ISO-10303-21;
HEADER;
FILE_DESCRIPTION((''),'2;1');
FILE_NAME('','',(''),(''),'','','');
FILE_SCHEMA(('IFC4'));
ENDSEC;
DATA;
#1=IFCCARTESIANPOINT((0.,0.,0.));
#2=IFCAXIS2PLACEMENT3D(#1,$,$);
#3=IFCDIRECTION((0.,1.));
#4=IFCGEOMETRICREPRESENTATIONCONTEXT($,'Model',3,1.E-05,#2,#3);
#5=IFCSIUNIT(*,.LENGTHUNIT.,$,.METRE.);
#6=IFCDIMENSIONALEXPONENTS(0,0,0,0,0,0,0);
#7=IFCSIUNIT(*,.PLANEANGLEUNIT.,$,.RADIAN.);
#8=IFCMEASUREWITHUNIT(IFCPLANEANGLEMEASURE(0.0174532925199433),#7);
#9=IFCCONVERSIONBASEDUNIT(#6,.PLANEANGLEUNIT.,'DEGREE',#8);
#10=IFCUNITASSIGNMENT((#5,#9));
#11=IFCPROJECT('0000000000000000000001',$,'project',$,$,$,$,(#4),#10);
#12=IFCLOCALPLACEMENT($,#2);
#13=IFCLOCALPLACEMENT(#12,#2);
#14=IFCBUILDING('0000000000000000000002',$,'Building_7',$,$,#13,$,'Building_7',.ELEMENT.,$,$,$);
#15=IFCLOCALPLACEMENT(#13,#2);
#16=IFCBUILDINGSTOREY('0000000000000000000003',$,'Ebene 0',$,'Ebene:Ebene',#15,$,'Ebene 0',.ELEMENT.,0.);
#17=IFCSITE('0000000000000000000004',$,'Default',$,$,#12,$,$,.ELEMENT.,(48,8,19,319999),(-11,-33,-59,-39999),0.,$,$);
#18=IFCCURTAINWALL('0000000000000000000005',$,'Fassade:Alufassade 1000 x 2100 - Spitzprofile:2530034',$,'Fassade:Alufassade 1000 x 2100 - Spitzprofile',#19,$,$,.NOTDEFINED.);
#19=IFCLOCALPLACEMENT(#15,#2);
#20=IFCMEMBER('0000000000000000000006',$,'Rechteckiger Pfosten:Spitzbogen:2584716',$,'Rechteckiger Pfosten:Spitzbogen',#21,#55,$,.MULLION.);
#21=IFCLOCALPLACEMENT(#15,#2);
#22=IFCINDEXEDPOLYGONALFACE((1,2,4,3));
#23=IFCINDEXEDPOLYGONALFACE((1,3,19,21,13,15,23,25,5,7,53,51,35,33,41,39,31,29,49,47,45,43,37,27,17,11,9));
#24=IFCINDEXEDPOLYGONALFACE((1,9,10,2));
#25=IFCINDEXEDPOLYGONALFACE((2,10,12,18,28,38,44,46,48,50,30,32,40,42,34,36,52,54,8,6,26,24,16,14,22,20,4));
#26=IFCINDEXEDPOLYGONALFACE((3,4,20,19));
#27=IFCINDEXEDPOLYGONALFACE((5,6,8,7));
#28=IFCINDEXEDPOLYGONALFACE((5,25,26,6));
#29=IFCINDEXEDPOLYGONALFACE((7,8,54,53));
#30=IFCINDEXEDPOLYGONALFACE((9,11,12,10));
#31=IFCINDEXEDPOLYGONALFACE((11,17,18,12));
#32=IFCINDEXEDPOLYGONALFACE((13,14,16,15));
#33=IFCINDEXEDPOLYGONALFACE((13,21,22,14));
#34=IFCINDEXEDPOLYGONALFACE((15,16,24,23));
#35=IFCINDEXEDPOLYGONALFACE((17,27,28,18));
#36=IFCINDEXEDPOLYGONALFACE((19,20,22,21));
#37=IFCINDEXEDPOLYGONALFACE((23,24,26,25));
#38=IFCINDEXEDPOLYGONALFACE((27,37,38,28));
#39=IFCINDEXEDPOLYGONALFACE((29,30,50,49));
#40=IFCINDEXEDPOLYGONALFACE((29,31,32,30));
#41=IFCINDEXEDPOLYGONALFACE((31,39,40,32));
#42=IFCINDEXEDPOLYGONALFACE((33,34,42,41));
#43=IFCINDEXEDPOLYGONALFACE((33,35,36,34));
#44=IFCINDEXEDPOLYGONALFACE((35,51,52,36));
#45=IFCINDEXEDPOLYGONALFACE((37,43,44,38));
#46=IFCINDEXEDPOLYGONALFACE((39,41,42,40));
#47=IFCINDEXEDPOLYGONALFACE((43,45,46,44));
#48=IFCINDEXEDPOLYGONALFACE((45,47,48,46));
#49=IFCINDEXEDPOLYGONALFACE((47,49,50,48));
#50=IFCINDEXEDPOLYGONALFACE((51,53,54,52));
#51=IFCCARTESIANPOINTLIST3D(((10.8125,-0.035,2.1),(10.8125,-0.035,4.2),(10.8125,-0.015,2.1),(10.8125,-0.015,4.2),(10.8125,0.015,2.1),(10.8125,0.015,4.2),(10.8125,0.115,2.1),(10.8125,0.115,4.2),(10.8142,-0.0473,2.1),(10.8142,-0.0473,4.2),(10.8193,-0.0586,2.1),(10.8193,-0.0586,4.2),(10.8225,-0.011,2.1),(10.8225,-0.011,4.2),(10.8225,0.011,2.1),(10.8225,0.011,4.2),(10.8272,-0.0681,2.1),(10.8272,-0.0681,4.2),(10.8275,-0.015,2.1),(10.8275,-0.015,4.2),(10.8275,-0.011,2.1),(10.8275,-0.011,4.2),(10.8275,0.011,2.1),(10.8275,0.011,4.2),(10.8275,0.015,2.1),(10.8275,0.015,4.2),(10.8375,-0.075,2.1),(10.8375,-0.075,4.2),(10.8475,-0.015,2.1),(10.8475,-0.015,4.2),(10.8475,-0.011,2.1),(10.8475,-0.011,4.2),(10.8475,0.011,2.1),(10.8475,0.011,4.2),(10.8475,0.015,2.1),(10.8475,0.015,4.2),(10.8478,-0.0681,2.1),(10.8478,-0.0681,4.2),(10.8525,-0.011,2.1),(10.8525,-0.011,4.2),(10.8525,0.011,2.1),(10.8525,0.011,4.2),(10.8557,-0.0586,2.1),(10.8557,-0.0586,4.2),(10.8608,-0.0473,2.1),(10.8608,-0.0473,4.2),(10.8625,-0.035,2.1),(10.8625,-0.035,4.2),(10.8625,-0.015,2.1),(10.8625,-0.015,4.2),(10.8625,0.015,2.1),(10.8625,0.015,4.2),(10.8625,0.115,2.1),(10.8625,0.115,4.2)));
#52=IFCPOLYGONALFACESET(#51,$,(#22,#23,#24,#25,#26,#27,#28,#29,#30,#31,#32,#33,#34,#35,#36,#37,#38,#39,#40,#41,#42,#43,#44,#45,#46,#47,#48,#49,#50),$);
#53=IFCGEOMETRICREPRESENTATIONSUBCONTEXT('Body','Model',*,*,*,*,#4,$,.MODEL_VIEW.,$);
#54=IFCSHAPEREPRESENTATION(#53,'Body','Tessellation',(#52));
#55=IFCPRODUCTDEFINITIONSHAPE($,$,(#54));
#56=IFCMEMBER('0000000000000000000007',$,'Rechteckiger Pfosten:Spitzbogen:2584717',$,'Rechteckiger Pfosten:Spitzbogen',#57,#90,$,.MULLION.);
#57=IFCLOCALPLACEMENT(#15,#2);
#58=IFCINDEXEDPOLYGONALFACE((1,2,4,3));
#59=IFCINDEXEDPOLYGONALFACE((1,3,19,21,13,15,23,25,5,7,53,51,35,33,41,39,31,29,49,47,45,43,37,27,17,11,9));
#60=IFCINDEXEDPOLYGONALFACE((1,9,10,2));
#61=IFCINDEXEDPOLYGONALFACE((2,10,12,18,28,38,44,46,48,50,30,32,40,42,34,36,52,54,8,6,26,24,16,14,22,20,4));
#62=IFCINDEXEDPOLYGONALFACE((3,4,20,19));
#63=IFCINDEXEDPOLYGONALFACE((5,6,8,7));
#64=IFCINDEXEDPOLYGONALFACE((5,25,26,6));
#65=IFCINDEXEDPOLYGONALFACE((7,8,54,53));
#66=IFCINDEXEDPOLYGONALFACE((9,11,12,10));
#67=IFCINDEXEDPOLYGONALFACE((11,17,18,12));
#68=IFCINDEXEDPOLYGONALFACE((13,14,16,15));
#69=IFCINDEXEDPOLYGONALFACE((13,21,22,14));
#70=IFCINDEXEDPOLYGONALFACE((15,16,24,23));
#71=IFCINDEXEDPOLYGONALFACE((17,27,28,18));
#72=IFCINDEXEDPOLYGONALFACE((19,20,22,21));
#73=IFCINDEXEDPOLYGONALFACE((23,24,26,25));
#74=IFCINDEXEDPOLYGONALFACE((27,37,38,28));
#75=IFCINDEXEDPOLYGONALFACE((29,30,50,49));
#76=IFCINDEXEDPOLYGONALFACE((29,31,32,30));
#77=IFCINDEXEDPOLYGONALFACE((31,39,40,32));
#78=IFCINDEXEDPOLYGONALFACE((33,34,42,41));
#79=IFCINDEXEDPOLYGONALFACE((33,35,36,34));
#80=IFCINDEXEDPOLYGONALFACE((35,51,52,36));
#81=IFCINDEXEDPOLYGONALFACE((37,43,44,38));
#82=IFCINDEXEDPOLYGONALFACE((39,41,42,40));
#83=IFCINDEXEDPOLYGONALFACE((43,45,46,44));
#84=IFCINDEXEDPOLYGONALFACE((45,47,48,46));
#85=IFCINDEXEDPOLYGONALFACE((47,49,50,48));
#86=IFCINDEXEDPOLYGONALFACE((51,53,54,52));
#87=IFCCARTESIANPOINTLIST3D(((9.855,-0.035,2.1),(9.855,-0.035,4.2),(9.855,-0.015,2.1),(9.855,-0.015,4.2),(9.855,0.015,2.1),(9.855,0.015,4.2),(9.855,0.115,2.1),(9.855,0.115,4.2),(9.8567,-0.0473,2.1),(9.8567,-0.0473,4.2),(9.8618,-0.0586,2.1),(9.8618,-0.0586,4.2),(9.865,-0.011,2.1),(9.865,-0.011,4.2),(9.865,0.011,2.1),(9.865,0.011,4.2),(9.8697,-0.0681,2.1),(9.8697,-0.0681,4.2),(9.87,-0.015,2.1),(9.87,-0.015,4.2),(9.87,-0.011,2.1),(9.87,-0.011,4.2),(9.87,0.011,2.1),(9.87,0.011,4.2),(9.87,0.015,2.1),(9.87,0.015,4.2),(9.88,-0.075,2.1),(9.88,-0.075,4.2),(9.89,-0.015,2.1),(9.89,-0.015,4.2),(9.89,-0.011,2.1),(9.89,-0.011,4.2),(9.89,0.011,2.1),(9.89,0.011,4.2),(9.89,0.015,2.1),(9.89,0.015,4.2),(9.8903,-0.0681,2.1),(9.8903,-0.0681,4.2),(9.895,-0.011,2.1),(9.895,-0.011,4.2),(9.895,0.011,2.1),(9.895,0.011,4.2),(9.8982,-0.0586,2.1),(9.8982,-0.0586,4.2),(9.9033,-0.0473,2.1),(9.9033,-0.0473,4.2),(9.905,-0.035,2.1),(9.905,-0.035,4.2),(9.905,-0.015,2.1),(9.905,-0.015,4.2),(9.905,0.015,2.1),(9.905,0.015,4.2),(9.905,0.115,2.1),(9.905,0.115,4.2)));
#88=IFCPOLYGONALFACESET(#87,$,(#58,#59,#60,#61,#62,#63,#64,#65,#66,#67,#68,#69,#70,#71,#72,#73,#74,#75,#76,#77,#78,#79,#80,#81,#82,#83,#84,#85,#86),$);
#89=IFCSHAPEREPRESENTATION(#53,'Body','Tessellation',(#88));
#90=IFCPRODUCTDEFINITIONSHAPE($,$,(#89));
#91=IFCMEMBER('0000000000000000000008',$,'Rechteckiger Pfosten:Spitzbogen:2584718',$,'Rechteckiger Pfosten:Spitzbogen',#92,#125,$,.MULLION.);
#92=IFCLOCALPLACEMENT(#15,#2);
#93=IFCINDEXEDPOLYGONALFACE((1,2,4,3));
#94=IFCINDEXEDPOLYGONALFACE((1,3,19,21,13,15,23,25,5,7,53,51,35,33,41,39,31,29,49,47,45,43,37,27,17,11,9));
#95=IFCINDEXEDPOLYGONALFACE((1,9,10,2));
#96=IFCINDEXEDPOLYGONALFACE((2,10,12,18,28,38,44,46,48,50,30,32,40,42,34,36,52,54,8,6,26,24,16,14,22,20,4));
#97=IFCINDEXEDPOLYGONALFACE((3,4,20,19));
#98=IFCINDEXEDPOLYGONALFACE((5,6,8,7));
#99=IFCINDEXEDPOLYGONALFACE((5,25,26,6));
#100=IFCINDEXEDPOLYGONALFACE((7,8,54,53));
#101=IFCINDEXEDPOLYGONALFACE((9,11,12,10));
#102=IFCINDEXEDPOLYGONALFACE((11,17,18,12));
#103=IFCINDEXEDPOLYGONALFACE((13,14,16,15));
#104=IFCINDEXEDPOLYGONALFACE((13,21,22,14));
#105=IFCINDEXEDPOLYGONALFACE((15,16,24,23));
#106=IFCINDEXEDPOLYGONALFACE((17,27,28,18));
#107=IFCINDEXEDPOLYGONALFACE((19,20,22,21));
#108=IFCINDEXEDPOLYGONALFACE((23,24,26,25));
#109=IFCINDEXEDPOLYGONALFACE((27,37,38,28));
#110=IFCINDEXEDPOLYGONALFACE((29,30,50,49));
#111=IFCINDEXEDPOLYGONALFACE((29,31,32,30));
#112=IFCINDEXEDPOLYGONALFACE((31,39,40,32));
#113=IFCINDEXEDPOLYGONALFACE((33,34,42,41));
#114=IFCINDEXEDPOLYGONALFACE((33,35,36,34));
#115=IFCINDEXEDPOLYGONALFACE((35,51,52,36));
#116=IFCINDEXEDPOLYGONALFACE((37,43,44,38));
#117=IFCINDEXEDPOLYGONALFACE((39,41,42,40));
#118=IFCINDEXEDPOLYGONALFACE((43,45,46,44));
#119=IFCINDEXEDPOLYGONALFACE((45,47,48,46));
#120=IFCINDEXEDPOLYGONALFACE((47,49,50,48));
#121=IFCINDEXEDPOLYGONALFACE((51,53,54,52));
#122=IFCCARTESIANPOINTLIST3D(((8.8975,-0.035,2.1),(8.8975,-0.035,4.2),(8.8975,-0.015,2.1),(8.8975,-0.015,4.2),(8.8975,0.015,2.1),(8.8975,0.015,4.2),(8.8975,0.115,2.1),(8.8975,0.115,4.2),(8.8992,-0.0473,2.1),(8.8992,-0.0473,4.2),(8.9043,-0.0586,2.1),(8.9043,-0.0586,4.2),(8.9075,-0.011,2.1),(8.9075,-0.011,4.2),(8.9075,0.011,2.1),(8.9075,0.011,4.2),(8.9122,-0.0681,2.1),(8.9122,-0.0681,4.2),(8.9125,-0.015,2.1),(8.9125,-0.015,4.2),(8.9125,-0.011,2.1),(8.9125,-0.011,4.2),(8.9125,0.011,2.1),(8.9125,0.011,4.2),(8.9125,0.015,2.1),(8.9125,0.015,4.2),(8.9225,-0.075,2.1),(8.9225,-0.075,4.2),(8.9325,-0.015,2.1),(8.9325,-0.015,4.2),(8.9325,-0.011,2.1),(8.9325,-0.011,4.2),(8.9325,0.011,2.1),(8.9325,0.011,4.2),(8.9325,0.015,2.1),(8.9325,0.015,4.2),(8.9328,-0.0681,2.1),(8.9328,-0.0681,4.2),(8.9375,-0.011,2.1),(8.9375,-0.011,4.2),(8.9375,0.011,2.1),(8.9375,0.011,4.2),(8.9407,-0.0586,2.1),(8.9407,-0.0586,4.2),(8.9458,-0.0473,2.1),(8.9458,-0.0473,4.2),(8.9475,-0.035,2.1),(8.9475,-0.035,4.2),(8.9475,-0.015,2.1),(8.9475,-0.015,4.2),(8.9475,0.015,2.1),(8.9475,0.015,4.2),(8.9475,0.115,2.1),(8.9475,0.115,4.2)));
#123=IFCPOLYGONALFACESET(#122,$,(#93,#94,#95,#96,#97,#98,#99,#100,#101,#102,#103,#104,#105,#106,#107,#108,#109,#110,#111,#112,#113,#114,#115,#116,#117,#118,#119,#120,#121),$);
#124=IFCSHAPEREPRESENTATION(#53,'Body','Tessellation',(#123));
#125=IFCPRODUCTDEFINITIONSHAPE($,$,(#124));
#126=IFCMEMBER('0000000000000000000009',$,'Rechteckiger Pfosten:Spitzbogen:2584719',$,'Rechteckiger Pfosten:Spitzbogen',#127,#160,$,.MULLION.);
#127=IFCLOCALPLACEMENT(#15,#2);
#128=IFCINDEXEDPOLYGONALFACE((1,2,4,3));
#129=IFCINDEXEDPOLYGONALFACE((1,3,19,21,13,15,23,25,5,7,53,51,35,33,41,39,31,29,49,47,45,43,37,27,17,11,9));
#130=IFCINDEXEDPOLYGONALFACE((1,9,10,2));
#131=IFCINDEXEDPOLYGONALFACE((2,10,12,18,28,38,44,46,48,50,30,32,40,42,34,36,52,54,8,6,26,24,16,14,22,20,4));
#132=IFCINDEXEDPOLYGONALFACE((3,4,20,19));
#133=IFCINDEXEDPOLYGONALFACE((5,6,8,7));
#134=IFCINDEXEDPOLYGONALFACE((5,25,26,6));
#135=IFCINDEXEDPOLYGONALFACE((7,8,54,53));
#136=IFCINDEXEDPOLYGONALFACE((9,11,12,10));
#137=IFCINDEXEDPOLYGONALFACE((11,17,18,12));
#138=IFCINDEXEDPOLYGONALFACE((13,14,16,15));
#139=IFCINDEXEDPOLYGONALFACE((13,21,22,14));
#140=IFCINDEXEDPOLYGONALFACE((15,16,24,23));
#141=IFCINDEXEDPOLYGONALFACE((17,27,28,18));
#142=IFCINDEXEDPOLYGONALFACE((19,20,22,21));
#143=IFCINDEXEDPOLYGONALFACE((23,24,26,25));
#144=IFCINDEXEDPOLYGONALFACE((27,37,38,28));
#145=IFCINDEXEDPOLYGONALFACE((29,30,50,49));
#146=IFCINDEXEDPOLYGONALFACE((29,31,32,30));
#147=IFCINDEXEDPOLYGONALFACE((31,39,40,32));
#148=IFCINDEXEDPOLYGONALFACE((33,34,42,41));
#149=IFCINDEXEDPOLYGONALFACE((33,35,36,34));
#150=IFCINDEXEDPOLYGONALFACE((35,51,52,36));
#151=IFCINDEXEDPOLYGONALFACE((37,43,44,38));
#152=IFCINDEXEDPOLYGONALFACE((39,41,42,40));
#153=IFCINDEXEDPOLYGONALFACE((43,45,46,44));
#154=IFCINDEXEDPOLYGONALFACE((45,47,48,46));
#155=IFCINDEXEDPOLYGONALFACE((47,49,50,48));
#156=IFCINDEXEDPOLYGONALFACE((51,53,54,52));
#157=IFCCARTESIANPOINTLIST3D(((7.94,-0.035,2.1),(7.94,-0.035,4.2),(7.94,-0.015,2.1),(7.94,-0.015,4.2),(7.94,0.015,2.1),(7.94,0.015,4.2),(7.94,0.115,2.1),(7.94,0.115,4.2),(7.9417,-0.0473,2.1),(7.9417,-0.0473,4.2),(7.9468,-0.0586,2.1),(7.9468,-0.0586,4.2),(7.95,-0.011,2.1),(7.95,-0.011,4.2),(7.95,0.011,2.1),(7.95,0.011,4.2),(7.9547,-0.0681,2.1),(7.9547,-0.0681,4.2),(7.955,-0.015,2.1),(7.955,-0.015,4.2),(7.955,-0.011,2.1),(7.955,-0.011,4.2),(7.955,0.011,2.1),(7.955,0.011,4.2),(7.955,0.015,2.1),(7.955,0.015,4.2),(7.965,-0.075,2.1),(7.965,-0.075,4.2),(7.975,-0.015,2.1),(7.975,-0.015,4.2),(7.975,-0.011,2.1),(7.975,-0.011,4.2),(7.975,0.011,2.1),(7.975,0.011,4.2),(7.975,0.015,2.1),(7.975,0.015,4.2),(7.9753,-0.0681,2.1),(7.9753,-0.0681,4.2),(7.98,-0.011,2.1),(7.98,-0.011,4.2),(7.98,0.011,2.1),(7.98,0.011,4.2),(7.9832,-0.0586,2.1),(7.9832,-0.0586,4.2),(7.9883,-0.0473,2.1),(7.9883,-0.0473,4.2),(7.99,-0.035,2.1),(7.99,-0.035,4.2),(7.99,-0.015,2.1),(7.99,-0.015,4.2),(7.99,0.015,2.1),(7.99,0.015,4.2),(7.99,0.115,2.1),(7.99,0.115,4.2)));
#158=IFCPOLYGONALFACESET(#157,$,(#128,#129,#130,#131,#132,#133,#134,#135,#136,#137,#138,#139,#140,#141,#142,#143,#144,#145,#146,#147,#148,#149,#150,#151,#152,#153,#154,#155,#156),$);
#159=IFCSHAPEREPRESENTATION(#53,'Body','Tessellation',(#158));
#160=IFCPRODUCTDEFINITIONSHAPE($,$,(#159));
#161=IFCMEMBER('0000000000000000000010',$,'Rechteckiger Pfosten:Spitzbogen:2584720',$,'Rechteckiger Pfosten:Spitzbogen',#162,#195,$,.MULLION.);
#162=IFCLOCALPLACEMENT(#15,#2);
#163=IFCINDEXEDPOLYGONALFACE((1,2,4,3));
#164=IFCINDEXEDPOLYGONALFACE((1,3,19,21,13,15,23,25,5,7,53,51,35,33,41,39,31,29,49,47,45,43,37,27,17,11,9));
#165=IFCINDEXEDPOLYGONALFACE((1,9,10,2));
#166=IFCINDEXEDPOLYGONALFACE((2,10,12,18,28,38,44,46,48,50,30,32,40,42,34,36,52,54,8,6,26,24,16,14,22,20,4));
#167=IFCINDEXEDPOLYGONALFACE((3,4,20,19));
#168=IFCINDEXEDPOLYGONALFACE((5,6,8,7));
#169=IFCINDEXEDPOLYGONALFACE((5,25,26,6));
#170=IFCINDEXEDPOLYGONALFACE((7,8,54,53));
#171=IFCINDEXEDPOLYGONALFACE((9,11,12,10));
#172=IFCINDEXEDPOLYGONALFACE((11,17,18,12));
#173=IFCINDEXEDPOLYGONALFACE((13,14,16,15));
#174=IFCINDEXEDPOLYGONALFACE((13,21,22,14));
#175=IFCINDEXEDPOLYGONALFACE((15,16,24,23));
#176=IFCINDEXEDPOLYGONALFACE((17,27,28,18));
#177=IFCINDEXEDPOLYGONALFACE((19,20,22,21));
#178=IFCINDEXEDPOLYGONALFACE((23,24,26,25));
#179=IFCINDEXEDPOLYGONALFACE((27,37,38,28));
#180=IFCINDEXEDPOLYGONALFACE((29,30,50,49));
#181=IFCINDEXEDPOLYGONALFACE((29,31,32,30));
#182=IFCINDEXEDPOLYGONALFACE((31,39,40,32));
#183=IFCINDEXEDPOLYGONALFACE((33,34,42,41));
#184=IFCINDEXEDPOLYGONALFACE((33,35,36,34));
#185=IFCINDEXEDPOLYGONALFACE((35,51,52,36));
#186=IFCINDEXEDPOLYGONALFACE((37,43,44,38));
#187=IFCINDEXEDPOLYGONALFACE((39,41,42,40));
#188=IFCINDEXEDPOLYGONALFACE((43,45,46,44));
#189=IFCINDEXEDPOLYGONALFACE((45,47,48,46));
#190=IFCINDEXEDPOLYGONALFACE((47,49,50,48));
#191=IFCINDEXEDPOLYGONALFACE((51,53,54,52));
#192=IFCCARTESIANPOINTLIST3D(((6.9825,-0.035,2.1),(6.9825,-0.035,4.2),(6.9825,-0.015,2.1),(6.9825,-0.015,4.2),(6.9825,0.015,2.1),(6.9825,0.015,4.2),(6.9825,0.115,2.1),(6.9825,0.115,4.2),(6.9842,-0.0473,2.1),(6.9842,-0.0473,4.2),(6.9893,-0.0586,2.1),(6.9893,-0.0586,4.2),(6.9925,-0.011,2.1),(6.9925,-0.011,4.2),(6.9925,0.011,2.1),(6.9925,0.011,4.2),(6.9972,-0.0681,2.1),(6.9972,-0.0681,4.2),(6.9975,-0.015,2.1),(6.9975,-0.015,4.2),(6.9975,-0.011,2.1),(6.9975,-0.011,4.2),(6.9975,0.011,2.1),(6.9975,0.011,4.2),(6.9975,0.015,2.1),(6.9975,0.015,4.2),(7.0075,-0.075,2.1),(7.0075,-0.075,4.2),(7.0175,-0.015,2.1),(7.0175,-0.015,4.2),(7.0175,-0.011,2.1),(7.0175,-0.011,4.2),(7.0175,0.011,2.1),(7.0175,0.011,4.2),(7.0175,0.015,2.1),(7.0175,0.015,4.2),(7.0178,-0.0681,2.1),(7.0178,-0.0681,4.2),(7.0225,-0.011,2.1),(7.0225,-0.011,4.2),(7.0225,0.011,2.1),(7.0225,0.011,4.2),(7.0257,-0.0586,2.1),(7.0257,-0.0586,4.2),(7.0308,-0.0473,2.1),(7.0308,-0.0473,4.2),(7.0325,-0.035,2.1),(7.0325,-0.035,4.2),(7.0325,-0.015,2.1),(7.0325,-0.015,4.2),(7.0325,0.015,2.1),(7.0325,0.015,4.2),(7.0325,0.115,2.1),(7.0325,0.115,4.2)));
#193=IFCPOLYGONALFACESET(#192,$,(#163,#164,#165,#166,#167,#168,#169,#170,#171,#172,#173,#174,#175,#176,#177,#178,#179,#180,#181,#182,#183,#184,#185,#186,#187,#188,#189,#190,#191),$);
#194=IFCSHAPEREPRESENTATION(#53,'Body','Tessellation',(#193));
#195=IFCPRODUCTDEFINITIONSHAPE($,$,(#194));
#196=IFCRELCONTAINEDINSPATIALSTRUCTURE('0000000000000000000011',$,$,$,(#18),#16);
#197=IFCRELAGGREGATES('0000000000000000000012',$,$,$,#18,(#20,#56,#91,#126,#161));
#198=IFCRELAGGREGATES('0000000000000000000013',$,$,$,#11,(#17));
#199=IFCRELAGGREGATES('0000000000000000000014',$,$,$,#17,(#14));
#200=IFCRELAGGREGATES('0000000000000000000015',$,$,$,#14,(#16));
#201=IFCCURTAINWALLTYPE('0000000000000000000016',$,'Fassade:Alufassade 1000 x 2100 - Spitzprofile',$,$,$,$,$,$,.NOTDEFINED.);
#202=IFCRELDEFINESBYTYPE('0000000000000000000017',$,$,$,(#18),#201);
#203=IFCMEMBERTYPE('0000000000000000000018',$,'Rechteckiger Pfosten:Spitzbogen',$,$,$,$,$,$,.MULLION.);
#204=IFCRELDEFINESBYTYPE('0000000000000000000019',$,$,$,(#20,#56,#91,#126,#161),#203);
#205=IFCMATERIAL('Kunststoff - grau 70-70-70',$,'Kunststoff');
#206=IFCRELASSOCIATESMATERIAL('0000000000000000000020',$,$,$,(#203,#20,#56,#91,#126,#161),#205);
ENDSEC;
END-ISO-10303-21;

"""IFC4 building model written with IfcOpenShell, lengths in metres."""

from ifc_helpers import new_model, entity, si_unit, converted_unit, direction, frame, origin, place, context, subcontext, project, spatial, line, arc, indexed_curve, outline, extrude, source, transform, mapped, material, type_object, type_shapes, element, aggregate, save


model = new_model("IFC4")

# Units and contexts
model_context = context("Model", 3, precision=1e-05, world=origin(), true_north=direction((0.0, 1.0)))
body_context = subcontext(model_context, "Body", "Model", "MODEL_VIEW")
ifc_project = project(units=[si_unit("LENGTHUNIT", "METRE"), converted_unit("PLANEANGLEUNIT", "DEGREE", entity("IfcPlaneAngleMeasure", 0.0174532925199433), si_unit("PLANEANGLEUNIT", "RADIAN"), dimensions=[0, 0, 0, 0, 0, 0, 0])], contexts=[model_context])

# Site, building, storey
site_placement = place(None, origin())
site = spatial("IfcSite", under=ifc_project, at=site_placement, Name="Default", CompositionType="ELEMENT", RefLatitude=(48, 8, 19, 319999), RefLongitude=(-11, -33, -59, -39999), RefElevation=0.0)
building_placement = place(site_placement, origin())
building = spatial("IfcBuilding", under=site, at=building_placement, Name="Building_7", LongName="Building_7", CompositionType="ELEMENT")
storey_placement = place(building_placement, origin())
storey = spatial("IfcBuildingStorey", under=building, at=storey_placement, Name="Ebene 0", ObjectType="Ebene:Ebene", LongName="Ebene 0", CompositionType="ELEMENT", Elevation=0.0)

# Curtain wall, members
curtain_wall_type = type_object("IfcCurtainWallType", Name="Fassade:Alufassade 1000 x 2100 - Spitzprofile", PredefinedType="NOTDEFINED")
curtain_wall_placement = place(storey_placement, origin())
curtain_wall = element("IfcCurtainWall", 1, at=curtain_wall_placement, inside=storey, type_object=curtain_wall_type, Name="Fassade:Alufassade 1000 x 2100 - Spitzprofile:2530034", ObjectType="Fassade:Alufassade 1000 x 2100 - Spitzprofile", PredefinedType="NOTDEFINED")
ifc_material = material(Name="Kunststoff - grau 70-70-70", Category="Kunststoff")
member_type_1 = type_object("IfcMemberType", Name="Rechteckiger Pfosten:Spitzbogen", PredefinedType="MULLION", material=ifc_material)
shared_shape_1 = source(origin(), body_context, "Body", "SweptSolid", [
    extrude(outline(indexed_curve([(-0.111, -0.025), (-0.011, -0.025), (-0.011, -0.01), (-0.007, -0.01), (-0.007, -0.015), (0.015, -0.015), (0.015, -0.01), (0.019, -0.01), (0.019, -0.025), (0.039, -0.025), (0.0626, -0.0182), (0.079, 0.0), (0.0626, 0.0182), (0.039, 0.025), (0.019, 0.025), (0.019, 0.01), (0.015, 0.01), (0.015, 0.015), (-0.007, 0.015), (-0.007, 0.01), (-0.011, 0.01), (-0.011, 0.025), (-0.111, 0.025)], segments=[line(1, 2, 3, 4, 5, 6, 7, 8, 9, 10), arc(10, 11, 12), arc(12, 13, 14), line(14, 15, 16, 17, 18, 19, 20, 21, 22, 23, 1)], self_intersect=False)), frame((0.0, 0.004, -2.1), z_axis=(0.0, 0.0, 1.0), x_axis=(0.0, -1.0, 0.0)), (0.0, 0.0, 1.0), 2.1),
])
type_shapes(member_type_1, [shared_shape_1])
member_1_placement = place(curtain_wall_placement, frame((10.8375, 0.0, 2.1), z_axis=(0.0, 0.0, -1.0), x_axis=(-1.0, 0.0, 0.0)))
member_1 = element("IfcMember", 2, at=member_1_placement, type_object=member_type_1, material=ifc_material, Name="Rechteckiger Pfosten:Spitzbogen:2584716", ObjectType="Rechteckiger Pfosten:Spitzbogen", PredefinedType="MULLION", context=body_context, shape_type="MappedRepresentation", body=[
    mapped(shared_shape_1, transform((0.0, 0.0, 0.0), scale=1.0)),
])
member_2_placement = place(curtain_wall_placement, frame((9.88, 0.0, 2.1), z_axis=(0.0, 0.0, -1.0), x_axis=(-1.0, 0.0, 0.0)))
member_2 = element("IfcMember", 3, at=member_2_placement, type_object=member_type_1, material=ifc_material, Name="Rechteckiger Pfosten:Spitzbogen:2584717", ObjectType="Rechteckiger Pfosten:Spitzbogen", PredefinedType="MULLION", context=body_context, shape_type="MappedRepresentation", body=[
    mapped(shared_shape_1, transform((0.0, 0.0, 0.0), scale=1.0)),
])
member_3_placement = place(curtain_wall_placement, frame((8.9225, 0.0, 2.1), z_axis=(0.0, 0.0, -1.0), x_axis=(-1.0, 0.0, 0.0)))
member_3 = element("IfcMember", 4, at=member_3_placement, type_object=member_type_1, material=ifc_material, Name="Rechteckiger Pfosten:Spitzbogen:2584718", ObjectType="Rechteckiger Pfosten:Spitzbogen", PredefinedType="MULLION", context=body_context, shape_type="MappedRepresentation", body=[
    mapped(shared_shape_1, transform((0.0, 0.0, 0.0), scale=1.0)),
])
member_4_placement = place(curtain_wall_placement, frame((7.965, 0.0, 2.1), z_axis=(0.0, 0.0, -1.0), x_axis=(-1.0, 0.0, 0.0)))
member_4 = element("IfcMember", 5, at=member_4_placement, type_object=member_type_1, material=ifc_material, Name="Rechteckiger Pfosten:Spitzbogen:2584719", ObjectType="Rechteckiger Pfosten:Spitzbogen", PredefinedType="MULLION", context=body_context, shape_type="MappedRepresentation", body=[
    mapped(shared_shape_1, transform((0.0, 0.0, 0.0), scale=1.0)),
])
member_5_placement = place(curtain_wall_placement, frame((7.0075, 0.0, 2.1), z_axis=(0.0, 0.0, -1.0), x_axis=(-1.0, 0.0, 0.0)))
member_5 = element("IfcMember", 6, at=member_5_placement, type_object=member_type_1, material=ifc_material, Name="Rechteckiger Pfosten:Spitzbogen:2584720", ObjectType="Rechteckiger Pfosten:Spitzbogen", PredefinedType="MULLION", context=body_context, shape_type="MappedRepresentation", body=[
    mapped(shared_shape_1, transform((0.0, 0.0, 0.0), scale=1.0)),
])
aggregate(curtain_wall, [member_1, member_2, member_3, member_4, member_5])

save(model, "model.ifc")
